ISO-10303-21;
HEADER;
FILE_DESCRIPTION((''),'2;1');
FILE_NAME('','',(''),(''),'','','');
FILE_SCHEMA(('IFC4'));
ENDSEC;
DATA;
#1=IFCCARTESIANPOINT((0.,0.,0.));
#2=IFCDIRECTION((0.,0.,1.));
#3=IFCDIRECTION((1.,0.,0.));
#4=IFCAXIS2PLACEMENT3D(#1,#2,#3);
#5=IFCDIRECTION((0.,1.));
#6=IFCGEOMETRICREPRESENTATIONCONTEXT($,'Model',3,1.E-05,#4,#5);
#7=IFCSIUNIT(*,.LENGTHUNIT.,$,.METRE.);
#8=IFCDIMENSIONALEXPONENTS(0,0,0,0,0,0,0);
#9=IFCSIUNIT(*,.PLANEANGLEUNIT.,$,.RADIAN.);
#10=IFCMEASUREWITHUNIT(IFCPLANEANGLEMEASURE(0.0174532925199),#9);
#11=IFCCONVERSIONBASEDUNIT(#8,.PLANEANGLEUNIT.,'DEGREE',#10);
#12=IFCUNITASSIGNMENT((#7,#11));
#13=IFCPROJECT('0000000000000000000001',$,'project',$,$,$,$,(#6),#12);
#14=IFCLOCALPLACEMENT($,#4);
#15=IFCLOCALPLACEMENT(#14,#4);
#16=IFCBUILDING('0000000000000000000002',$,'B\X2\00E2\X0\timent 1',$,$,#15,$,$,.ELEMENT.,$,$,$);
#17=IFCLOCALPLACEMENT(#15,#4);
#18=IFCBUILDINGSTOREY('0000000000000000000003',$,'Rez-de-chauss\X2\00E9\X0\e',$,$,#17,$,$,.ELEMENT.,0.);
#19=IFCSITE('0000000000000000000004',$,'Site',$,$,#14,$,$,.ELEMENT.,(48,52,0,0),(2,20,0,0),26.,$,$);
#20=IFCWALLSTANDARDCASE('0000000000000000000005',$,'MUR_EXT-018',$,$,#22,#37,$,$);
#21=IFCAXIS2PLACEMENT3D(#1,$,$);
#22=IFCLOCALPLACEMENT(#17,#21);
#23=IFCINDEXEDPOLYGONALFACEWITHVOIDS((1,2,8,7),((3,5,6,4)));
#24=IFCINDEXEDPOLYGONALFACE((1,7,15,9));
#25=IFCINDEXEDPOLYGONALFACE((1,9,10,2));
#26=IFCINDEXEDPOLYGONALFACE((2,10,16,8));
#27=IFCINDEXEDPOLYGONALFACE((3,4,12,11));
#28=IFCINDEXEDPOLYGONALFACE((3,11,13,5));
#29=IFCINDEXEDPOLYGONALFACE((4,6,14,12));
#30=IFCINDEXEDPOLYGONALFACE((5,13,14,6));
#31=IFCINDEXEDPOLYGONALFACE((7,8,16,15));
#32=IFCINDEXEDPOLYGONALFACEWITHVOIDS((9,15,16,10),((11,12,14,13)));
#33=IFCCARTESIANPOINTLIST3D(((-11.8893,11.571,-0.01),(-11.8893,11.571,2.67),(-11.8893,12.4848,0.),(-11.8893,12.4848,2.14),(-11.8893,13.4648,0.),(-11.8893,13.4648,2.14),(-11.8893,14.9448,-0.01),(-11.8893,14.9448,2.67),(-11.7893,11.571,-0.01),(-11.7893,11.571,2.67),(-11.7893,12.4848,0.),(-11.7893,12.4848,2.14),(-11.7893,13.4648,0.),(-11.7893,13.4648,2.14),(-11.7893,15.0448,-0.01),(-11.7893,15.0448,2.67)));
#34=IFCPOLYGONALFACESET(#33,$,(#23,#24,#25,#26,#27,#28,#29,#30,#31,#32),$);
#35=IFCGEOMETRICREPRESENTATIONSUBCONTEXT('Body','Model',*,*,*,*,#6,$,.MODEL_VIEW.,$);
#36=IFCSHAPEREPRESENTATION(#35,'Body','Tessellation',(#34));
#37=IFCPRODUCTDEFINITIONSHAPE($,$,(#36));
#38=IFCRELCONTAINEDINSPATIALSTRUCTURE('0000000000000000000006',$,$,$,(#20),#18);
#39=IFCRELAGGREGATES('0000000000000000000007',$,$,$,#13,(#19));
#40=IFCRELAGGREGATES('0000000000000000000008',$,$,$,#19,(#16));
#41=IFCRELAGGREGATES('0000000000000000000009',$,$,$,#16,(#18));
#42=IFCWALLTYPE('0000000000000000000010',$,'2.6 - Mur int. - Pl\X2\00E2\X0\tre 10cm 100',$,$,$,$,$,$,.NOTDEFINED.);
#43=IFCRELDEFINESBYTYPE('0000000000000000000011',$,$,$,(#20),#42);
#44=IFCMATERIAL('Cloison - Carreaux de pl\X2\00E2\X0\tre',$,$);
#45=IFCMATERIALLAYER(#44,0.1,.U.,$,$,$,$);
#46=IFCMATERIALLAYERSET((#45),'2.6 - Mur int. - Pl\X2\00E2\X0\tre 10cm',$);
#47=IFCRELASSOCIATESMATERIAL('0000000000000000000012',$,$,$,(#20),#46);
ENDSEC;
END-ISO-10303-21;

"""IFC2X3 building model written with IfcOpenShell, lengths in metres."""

from ifc_helpers import new_model, entity, si_unit, converted_unit, direction, frame, origin_with_axes, origin_2d_with_axis, place, context, subcontext, project, spatial, polyline, rectangle, outline, extrude, material, layer, layer_set, layer_usage, type_object, element, save


model = new_model("IFC2X3")

# Units and contexts
model_context = context("Model", 3, precision=1e-05, world=origin_with_axes(), true_north=direction((0.0, 1.0)))
body_context = subcontext(model_context, "Body", "Model", "MODEL_VIEW")
ifc_project = project(units=[si_unit("LENGTHUNIT", "METRE"), converted_unit("PLANEANGLEUNIT", "DEGREE", entity("IfcPlaneAngleMeasure", 0.0174532925199), si_unit("PLANEANGLEUNIT", "RADIAN"), dimensions=[0, 0, 0, 0, 0, 0, 0])], contexts=[model_context])

# Site, building, storey
site_placement = place(None, origin_with_axes())
site = spatial("IfcSite", under=ifc_project, at=site_placement, Name="Site", CompositionType="ELEMENT", RefLatitude=(48, 52, 0, 0), RefLongitude=(2, 20, 0, 0), RefElevation=26.0)
building_placement = place(site_placement, origin_with_axes())
building = spatial("IfcBuilding", under=site, at=building_placement, Name="Bâtiment 1", CompositionType="ELEMENT")
storey_placement = place(building_placement, origin_with_axes())
storey = spatial("IfcBuildingStorey", under=building, at=storey_placement, Name="Rez-de-chaussée", CompositionType="ELEMENT", Elevation=0.0)

# Wall, opening
ifc_material_1 = material(Name="Cloison - Carreaux de plâtre")
ifc_layer_1 = layer(ifc_material_1, 0.1, ventilated="UNKNOWN")
ifc_layer_set_1 = layer_set([ifc_layer_1], Name="2.6 - Mur int. - Plâtre 10cm")
wall_type_1 = type_object("IfcWallType", Name="2.6 - Mur int. - Plâtre 10cm 100", PredefinedType="NOTDEFINED")
ifc_layer_usage_1 = layer_usage(ifc_layer_set_1, "AXIS2", "POSITIVE", -0.05)
wall_1_placement = place(storey_placement, frame((-11.8393, 14.9948, -0.01), z_axis=(0.0, 0.0, 1.0), x_axis=(0.0, -1.0, 0.0)))
wall_1 = element("IfcWallStandardCase", 1, at=wall_1_placement, inside=storey, type_object=wall_type_1, material=ifc_layer_usage_1, Name="MUR_EXT-018", context=body_context, shape_type="SweptSolid", body=[
    extrude(outline(polyline([(0.05, -0.05), (3.4238, -0.05), (3.4238, 0.05), (-0.05, 0.05), (0.05, -0.05)])), origin_with_axes(), (0.0, 0.0, 1.0), 2.68),
])
opening_1_placement = place(wall_1_placement, frame((2.02, 0.0, 0.01), z_axis=(0.0, 0.0, 1.0), x_axis=(1.0, 0.0, 0.0)))
element("IfcOpeningElement", 2, at=opening_1_placement, cuts=wall_1, context=body_context, shape_type="SweptSolid", body=[
    extrude(rectangle(XDim=0.98, YDim=2.14, at=origin_2d_with_axis()), frame((0.0, -0.1, 1.07), z_axis=(0.0, -1.0, 0.0), x_axis=(-1.0, 0.0, 0.0)), (0.0, 0.0, -1.0), 0.3),
])

save(model, "model.ifc")
